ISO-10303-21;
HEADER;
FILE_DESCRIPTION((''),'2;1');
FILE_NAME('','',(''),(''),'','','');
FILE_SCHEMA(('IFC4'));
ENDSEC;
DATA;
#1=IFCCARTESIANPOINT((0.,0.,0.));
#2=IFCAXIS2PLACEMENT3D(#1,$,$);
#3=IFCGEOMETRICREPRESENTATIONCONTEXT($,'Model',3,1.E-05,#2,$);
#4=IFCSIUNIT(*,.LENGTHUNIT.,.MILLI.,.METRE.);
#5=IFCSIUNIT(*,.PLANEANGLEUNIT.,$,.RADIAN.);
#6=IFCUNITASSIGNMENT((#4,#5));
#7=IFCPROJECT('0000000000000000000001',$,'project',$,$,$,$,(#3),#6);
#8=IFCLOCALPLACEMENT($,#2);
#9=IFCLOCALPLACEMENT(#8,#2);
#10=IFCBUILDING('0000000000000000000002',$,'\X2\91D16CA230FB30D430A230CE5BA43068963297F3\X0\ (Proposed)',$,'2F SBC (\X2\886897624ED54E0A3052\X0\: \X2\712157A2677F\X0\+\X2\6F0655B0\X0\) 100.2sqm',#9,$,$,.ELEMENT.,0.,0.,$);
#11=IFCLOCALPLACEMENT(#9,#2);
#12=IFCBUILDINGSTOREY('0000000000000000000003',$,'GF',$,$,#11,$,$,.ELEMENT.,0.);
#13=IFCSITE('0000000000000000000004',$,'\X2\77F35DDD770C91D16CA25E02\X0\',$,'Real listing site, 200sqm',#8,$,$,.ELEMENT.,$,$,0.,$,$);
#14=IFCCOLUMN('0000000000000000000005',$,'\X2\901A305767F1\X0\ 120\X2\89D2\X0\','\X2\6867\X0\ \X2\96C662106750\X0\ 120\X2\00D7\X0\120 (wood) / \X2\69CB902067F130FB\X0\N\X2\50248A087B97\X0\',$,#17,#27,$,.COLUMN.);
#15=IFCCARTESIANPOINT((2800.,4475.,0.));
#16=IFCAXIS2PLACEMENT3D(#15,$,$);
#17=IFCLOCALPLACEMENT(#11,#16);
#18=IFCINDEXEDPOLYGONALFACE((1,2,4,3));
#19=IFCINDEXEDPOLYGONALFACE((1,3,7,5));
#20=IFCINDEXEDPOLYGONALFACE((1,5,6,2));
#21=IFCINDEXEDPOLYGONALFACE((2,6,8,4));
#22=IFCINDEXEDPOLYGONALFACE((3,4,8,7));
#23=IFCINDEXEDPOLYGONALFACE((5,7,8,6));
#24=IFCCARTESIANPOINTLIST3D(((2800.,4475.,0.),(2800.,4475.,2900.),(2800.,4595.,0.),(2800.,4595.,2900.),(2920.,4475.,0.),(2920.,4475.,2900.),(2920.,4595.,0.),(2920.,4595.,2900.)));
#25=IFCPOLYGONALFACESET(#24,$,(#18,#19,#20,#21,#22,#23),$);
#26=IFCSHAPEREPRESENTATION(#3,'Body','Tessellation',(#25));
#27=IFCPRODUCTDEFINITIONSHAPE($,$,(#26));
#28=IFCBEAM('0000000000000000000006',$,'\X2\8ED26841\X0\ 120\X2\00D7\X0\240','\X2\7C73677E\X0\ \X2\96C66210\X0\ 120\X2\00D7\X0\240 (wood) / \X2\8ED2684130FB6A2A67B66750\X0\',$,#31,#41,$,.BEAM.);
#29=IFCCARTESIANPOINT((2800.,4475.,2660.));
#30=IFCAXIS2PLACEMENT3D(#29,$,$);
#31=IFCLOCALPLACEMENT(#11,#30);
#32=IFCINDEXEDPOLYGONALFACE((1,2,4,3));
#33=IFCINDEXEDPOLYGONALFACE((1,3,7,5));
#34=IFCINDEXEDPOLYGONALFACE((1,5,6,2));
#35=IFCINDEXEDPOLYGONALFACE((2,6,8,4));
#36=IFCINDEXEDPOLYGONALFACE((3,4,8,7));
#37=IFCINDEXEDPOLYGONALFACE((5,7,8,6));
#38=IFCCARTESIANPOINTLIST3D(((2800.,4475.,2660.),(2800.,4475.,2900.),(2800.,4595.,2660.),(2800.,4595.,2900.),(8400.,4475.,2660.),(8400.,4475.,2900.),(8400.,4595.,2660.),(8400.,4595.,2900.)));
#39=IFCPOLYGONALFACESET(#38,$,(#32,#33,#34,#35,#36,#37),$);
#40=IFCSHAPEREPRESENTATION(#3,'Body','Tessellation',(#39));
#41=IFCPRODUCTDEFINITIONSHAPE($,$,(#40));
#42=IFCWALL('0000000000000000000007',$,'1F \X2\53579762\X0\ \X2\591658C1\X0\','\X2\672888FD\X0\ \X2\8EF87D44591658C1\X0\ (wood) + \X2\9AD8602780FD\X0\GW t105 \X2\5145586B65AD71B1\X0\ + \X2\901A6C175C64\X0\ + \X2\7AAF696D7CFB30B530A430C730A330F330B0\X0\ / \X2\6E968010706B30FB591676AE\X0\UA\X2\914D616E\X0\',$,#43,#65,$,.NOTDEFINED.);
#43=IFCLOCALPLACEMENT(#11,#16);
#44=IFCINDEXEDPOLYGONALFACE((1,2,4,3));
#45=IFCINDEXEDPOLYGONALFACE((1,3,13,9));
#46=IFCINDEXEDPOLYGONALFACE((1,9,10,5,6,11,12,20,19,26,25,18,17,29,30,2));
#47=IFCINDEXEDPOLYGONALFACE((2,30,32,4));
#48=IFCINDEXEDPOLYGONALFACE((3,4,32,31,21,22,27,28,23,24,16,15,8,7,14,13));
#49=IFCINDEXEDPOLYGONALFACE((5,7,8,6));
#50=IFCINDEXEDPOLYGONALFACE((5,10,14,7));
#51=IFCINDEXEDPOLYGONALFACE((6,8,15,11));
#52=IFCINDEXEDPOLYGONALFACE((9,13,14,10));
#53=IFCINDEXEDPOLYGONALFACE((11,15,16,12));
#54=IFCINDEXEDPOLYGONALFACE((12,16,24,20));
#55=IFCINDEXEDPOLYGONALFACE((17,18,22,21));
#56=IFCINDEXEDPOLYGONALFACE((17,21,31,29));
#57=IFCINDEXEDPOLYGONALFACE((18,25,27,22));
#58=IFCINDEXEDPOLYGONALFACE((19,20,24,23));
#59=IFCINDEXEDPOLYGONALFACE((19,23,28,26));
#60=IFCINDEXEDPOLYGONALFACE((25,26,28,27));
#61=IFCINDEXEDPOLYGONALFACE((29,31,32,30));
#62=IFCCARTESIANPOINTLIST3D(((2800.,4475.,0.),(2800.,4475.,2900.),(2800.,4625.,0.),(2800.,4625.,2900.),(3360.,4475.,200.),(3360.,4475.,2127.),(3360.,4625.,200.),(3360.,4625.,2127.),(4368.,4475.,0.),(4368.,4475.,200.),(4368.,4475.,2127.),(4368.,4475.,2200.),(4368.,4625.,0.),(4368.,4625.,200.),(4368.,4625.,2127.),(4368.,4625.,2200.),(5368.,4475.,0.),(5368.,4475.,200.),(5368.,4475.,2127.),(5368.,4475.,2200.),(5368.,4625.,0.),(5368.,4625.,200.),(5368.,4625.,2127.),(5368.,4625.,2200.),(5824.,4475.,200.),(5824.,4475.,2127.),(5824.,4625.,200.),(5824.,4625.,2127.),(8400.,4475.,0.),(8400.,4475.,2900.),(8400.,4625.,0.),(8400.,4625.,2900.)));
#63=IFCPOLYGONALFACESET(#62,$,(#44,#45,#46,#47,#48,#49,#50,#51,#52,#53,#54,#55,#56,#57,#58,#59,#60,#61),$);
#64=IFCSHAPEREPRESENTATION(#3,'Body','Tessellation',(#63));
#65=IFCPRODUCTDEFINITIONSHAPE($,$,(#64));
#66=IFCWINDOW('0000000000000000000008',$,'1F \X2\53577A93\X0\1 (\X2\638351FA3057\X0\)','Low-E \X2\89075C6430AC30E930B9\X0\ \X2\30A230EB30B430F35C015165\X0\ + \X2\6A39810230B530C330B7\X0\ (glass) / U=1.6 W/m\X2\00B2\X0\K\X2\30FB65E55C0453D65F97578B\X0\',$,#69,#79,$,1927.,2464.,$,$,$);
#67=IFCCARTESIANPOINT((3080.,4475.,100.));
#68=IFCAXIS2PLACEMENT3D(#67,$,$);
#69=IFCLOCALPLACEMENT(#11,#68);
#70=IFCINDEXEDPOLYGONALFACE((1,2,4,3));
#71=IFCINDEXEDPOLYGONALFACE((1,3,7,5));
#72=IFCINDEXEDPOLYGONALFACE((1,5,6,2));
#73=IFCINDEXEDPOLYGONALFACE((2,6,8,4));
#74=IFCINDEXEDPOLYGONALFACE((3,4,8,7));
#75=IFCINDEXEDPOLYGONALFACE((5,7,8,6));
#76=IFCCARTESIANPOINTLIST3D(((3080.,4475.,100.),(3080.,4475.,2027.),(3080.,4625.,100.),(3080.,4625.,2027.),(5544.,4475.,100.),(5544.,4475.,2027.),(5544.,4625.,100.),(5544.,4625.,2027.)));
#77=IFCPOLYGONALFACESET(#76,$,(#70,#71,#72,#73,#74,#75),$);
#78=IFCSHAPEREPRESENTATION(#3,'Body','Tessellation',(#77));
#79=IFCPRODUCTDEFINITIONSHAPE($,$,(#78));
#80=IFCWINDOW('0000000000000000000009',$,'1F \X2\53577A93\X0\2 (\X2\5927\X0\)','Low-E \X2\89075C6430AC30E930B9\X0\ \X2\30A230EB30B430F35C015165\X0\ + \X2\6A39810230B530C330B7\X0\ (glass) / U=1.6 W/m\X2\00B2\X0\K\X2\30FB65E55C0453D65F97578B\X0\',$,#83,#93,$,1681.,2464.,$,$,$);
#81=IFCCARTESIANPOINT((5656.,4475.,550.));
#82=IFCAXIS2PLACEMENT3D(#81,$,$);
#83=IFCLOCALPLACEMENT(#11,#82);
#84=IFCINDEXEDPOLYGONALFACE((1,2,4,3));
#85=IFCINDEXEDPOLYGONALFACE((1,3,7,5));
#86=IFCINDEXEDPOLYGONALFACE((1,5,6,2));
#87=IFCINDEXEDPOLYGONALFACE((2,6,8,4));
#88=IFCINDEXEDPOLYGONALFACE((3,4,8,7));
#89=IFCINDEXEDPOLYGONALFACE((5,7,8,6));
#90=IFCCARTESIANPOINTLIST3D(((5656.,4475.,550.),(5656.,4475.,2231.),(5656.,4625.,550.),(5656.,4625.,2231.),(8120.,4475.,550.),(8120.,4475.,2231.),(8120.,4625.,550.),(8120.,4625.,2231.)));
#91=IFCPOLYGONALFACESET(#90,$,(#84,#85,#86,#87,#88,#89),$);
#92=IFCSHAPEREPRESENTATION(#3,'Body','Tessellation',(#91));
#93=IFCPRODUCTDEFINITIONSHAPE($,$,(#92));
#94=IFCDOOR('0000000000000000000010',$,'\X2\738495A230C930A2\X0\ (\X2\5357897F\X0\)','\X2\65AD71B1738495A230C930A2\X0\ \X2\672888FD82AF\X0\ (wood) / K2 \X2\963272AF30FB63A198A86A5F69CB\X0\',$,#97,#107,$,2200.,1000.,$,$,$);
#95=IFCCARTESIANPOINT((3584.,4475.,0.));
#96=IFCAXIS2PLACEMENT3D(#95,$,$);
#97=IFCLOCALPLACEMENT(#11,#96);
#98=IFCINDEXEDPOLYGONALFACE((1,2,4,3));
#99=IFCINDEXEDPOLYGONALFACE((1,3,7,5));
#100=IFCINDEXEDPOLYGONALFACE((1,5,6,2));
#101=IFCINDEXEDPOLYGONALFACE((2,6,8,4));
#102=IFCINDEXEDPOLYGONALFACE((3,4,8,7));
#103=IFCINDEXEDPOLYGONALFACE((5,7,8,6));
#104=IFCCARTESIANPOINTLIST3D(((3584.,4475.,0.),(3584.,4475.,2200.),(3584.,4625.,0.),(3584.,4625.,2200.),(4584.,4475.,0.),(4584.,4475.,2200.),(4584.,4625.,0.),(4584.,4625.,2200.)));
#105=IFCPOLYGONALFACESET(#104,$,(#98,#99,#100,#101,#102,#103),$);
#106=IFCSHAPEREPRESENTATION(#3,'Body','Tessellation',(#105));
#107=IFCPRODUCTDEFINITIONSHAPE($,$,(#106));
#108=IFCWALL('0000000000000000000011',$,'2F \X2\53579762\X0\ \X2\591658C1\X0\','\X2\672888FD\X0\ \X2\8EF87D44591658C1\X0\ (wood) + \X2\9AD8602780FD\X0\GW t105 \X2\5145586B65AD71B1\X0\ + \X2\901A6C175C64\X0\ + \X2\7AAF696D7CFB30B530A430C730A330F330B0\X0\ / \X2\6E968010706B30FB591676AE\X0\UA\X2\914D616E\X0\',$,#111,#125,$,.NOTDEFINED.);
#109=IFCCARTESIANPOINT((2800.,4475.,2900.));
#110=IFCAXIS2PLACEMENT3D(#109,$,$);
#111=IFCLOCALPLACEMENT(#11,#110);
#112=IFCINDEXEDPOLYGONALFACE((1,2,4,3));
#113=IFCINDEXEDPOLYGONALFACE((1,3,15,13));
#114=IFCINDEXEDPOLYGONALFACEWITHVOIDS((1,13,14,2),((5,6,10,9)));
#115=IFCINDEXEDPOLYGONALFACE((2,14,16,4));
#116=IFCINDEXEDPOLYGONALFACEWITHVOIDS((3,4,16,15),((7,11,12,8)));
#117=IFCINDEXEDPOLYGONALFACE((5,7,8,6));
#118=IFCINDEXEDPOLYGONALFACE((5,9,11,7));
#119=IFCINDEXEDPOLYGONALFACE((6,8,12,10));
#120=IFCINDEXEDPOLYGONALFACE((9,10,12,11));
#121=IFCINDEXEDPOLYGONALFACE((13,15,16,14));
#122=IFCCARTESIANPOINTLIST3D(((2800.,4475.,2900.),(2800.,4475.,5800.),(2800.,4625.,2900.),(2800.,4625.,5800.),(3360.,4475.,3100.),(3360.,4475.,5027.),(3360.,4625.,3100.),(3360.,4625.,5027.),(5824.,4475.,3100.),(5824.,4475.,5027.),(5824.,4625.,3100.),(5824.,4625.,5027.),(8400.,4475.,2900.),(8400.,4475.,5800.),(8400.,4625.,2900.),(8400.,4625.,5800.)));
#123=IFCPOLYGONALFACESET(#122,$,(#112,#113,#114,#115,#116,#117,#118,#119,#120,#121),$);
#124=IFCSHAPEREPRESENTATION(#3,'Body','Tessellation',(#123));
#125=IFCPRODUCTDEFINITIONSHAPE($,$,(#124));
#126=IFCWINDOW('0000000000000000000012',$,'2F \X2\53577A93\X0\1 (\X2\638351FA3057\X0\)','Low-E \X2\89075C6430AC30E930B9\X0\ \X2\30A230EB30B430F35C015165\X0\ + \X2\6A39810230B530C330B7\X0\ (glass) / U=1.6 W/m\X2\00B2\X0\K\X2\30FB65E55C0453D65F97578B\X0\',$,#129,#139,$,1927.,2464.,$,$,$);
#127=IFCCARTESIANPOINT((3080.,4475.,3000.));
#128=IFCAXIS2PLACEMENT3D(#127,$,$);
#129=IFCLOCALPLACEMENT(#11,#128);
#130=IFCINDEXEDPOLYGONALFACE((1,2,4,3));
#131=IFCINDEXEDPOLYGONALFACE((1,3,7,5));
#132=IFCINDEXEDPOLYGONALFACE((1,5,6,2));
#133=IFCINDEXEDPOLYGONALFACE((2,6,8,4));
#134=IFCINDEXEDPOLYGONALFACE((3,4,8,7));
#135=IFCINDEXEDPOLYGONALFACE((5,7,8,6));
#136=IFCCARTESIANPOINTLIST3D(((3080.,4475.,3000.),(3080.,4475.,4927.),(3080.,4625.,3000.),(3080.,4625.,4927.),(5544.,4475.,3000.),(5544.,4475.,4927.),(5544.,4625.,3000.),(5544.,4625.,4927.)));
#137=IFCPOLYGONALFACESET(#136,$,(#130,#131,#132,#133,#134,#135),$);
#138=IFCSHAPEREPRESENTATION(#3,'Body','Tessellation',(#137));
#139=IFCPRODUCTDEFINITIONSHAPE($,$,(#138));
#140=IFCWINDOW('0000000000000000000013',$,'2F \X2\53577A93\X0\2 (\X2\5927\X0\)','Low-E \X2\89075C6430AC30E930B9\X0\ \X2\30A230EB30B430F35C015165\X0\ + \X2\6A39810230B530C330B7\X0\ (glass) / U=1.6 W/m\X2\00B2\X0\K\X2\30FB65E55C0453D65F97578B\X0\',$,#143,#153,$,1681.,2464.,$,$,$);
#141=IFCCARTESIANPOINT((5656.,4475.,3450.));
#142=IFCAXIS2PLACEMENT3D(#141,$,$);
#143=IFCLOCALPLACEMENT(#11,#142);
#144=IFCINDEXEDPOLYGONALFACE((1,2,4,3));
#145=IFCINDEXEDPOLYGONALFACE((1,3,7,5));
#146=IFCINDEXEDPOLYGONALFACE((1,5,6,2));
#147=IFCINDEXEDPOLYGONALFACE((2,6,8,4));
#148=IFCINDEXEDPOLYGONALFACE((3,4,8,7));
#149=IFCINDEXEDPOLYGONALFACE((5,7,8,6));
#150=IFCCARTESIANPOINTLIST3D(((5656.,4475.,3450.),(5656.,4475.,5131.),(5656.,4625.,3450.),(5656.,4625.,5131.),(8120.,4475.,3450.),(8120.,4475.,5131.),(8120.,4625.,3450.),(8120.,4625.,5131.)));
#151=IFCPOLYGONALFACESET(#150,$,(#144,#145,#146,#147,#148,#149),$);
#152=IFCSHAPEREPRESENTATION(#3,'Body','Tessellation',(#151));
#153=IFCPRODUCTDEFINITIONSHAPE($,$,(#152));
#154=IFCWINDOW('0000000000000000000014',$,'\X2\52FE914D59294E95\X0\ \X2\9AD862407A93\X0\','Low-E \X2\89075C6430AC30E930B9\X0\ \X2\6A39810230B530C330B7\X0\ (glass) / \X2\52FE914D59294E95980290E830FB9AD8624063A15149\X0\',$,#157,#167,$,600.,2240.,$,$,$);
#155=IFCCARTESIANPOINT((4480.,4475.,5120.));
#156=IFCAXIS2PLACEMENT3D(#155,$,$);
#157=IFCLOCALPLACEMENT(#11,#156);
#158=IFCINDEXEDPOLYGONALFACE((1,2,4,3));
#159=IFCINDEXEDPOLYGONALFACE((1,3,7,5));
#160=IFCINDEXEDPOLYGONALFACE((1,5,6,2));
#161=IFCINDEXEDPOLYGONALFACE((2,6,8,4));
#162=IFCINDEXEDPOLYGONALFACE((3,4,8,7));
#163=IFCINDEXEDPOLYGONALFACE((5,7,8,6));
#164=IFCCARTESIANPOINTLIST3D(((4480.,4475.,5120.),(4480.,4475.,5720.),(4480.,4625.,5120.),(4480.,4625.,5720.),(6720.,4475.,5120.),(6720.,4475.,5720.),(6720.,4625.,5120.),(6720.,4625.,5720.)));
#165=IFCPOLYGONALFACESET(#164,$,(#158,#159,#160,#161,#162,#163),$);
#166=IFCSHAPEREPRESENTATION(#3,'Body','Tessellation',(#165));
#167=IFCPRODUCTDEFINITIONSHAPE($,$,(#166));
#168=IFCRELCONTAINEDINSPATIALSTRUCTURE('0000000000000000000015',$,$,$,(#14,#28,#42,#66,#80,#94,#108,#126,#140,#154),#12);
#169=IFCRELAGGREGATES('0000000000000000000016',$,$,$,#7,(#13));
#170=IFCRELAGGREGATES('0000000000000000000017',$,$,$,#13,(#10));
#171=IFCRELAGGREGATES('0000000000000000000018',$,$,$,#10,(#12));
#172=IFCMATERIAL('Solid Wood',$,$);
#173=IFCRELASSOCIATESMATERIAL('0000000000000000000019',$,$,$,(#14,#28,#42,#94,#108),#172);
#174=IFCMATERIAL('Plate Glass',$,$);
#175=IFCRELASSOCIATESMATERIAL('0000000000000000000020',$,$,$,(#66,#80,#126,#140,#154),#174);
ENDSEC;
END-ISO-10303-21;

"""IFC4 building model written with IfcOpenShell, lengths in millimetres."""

from ifc_helpers import new_model, si_unit, frame, frame_2d, origin, place, context, project, spatial, rectangle, extrude, material, element, fill, save


model = new_model("IFC4")

# Units and contexts
model_context = context("Model", 3, precision=1e-05, world=origin())
ifc_project = project(units=[si_unit("LENGTHUNIT", "METRE", prefix="MILLI"), si_unit("PLANEANGLEUNIT", "RADIAN")], contexts=[model_context])

# Site, building, storey
site_placement = place(None, origin())
site = spatial("IfcSite", under=ifc_project, at=site_placement, Name="石川県金沢市", ObjectType="Real listing site, 200sqm", CompositionType="ELEMENT", RefElevation=0.0)
building_placement = place(site_placement, origin())
building = spatial("IfcBuilding", under=site, at=building_placement, Name="金沢・ピアノ室と防音 (Proposed)", ObjectType="2F SBC (表面仕上げ: 無垢板+漆喰) 100.2sqm", CompositionType="ELEMENT", ElevationOfRefHeight=0.0, ElevationOfTerrain=0.0)
storey_placement = place(building_placement, origin())
storey = spatial("IfcBuildingStorey", under=building, at=storey_placement, Name="GF", CompositionType="ELEMENT", Elevation=0.0)

# Column
ifc_material_1 = material(Name="Solid Wood")
column_placement = place(storey_placement, frame((2800.0, 4475.0, 0.0)))
element("IfcColumn", 1, at=column_placement, inside=storey, material=ifc_material_1, Name="通し柱 120角", Description="桧 集成材 120×120 (wood) / 構造柱・N値計算", PredefinedType="COLUMN", context=model_context, shape_type="SweptSolid", body=[
    extrude(rectangle(XDim=120.0, YDim=120.0, at=frame_2d((60.0, 60.0))), frame((2800.0, 4475.0, 0.0)), (0.0, 0.0, 1.0), 2900.0),
])

# Beam
beam_1_placement = place(storey_placement, frame((2800.0, 4475.0, 2660.0)))
element("IfcBeam", 2, at=beam_1_placement, inside=storey, material=ifc_material_1, Name="軒桁 120×240", Description="米松 集成 120×240 (wood) / 軒桁・横架材", PredefinedType="BEAM", context=model_context, shape_type="SweptSolid", body=[
    extrude(rectangle(XDim=5600.0, YDim=120.0, at=frame_2d((2800.0, 60.0))), frame((2800.0, 4475.0, 2660.0)), (0.0, 0.0, 1.0), 240.0),
])

# Wall, openings, windows, door
wall_1_placement = place(storey_placement, frame((2800.0, 4475.0, 0.0)))
wall_1 = element("IfcWall", 3, at=wall_1_placement, inside=storey, material=ifc_material_1, Name="1F 南面 外壁", Description="木製 軸組外壁 (wood) + 高性能GW t105 充填断熱 + 通気層 + 窯業系サイディング / 準耐火・外皮UA配慮", PredefinedType="NOTDEFINED", context=model_context, shape_type="SweptSolid", body=[
    extrude(rectangle(XDim=5600.0, YDim=150.0, at=frame_2d((2800.0, 75.0))), frame((2800.0, 4475.0, 0.0)), (0.0, 0.0, 1.0), 2900.0),
])
opening_1_placement = place(storey_placement, frame((3080.0, 4475.0, 100.0)))
opening_1 = element("IfcOpeningElement", 4, at=opening_1_placement, cuts=wall_1, PredefinedType="NOTDEFINED", context=model_context, shape_type="SweptSolid", body=[
    extrude(rectangle(XDim=2464.0, YDim=150.0, at=frame_2d((1232.0, 75.0))), frame((3080.0, 4475.0, 100.0)), (0.0, 0.0, 1.0), 1927.0),
])
opening_2_placement = place(storey_placement, frame((5656.0, 4475.0, 550.0)))
opening_2 = element("IfcOpeningElement", 5, at=opening_2_placement, cuts=wall_1, PredefinedType="NOTDEFINED", context=model_context, shape_type="SweptSolid", body=[
    extrude(rectangle(XDim=2464.0, YDim=150.0, at=frame_2d((1232.0, 75.0))), frame((5656.0, 4475.0, 550.0)), (0.0, 0.0, 1.0), 1681.0),
])
opening_3_placement = place(storey_placement, frame((3584.0, 4475.0, 0.0)))
opening_3 = element("IfcOpeningElement", 6, at=opening_3_placement, cuts=wall_1, PredefinedType="NOTDEFINED", context=model_context, shape_type="SweptSolid", body=[
    extrude(rectangle(XDim=1000.0, YDim=150.0, at=frame_2d((500.0, 75.0))), frame((3584.0, 4475.0, 0.0)), (0.0, 0.0, 1.0), 2200.0),
])
ifc_material_2 = material(Name="Plate Glass")
window_1_placement = place(storey_placement, frame((3080.0, 4475.0, 100.0)))
window_1 = element("IfcWindow", 7, at=window_1_placement, inside=storey, material=ifc_material_2, Name="1F 南窓1 (掃出し)", Description="Low-E 複層ガラス アルゴン封入 + 樹脂サッシ (glass) / U=1.6 W/m²K・日射取得型", OverallHeight=1927.0, OverallWidth=2464.0, context=model_context, shape_type="SweptSolid", body=[
    extrude(rectangle(XDim=2464.0, YDim=150.0, at=frame_2d((1232.0, 75.0))), frame((3080.0, 4475.0, 100.0)), (0.0, 0.0, 1.0), 1927.0),
])
fill(opening_1, window_1)
window_2_placement = place(storey_placement, frame((5656.0, 4475.0, 550.0)))
window_2 = element("IfcWindow", 8, at=window_2_placement, inside=storey, material=ifc_material_2, Name="1F 南窓2 (大)", Description="Low-E 複層ガラス アルゴン封入 + 樹脂サッシ (glass) / U=1.6 W/m²K・日射取得型", OverallHeight=1681.0, OverallWidth=2464.0, context=model_context, shape_type="SweptSolid", body=[
    extrude(rectangle(XDim=2464.0, YDim=150.0, at=frame_2d((1232.0, 75.0))), frame((5656.0, 4475.0, 550.0)), (0.0, 0.0, 1.0), 1681.0),
])
fill(opening_2, window_2)
door_placement = place(storey_placement, frame((3584.0, 4475.0, 0.0)))
door = element("IfcDoor", 9, at=door_placement, inside=storey, material=ifc_material_1, Name="玄関ドア (南西)", Description="断熱玄関ドア 木製芯 (wood) / K2 防犯・採風機構", OverallHeight=2200.0, OverallWidth=1000.0, context=model_context, shape_type="SweptSolid", body=[
    extrude(rectangle(XDim=1000.0, YDim=150.0, at=frame_2d((500.0, 75.0))), frame((3584.0, 4475.0, 0.0)), (0.0, 0.0, 1.0), 2200.0),
])
fill(opening_3, door)

# Wall, openings, windows
wall_2_placement = place(storey_placement, frame((2800.0, 4475.0, 2900.0)))
wall_2 = element("IfcWall", 10, at=wall_2_placement, inside=storey, material=ifc_material_1, Name="2F 南面 外壁", Description="木製 軸組外壁 (wood) + 高性能GW t105 充填断熱 + 通気層 + 窯業系サイディング / 準耐火・外皮UA配慮", PredefinedType="NOTDEFINED", context=model_context, shape_type="SweptSolid", body=[
    extrude(rectangle(XDim=5600.0, YDim=150.0, at=frame_2d((2800.0, 75.0))), frame((2800.0, 4475.0, 2900.0)), (0.0, 0.0, 1.0), 2900.0),
])
opening_4_placement = place(storey_placement, frame((3080.0, 4475.0, 3000.0)))
opening_4 = element("IfcOpeningElement", 11, at=opening_4_placement, cuts=wall_2, PredefinedType="NOTDEFINED", context=model_context, shape_type="SweptSolid", body=[
    extrude(rectangle(XDim=2464.0, YDim=150.0, at=frame_2d((1232.0, 75.0))), frame((3080.0, 4475.0, 3000.0)), (0.0, 0.0, 1.0), 1927.0),
])
opening_5_placement = place(storey_placement, frame((5656.0, 4475.0, 3450.0)))
opening_5 = element("IfcOpeningElement", 12, at=opening_5_placement, cuts=wall_2, PredefinedType="NOTDEFINED", context=model_context, shape_type="SweptSolid", body=[
    extrude(rectangle(XDim=2464.0, YDim=150.0, at=frame_2d((1232.0, 75.0))), frame((5656.0, 4475.0, 3450.0)), (0.0, 0.0, 1.0), 1681.0),
])
opening_6_placement = place(storey_placement, frame((4480.0, 4475.0, 5120.0)))
opening_6 = element("IfcOpeningElement", 13, at=opening_6_placement, cuts=wall_2, PredefinedType="NOTDEFINED", context=model_context, shape_type="SweptSolid", body=[
    extrude(rectangle(XDim=2240.0, YDim=150.0, at=frame_2d((1120.0, 75.0))), frame((4480.0, 4475.0, 5120.0)), (0.0, 0.0, 1.0), 600.0),
])
window_3_placement = place(storey_placement, frame((3080.0, 4475.0, 3000.0)))
window_3 = element("IfcWindow", 14, at=window_3_placement, inside=storey, material=ifc_material_2, Name="2F 南窓1 (掃出し)", Description="Low-E 複層ガラス アルゴン封入 + 樹脂サッシ (glass) / U=1.6 W/m²K・日射取得型", OverallHeight=1927.0, OverallWidth=2464.0, context=model_context, shape_type="SweptSolid", body=[
    extrude(rectangle(XDim=2464.0, YDim=150.0, at=frame_2d((1232.0, 75.0))), frame((3080.0, 4475.0, 3000.0)), (0.0, 0.0, 1.0), 1927.0),
])
fill(opening_4, window_3)
window_4_placement = place(storey_placement, frame((5656.0, 4475.0, 3450.0)))
window_4 = element("IfcWindow", 15, at=window_4_placement, inside=storey, material=ifc_material_2, Name="2F 南窓2 (大)", Description="Low-E 複層ガラス アルゴン封入 + 樹脂サッシ (glass) / U=1.6 W/m²K・日射取得型", OverallHeight=1681.0, OverallWidth=2464.0, context=model_context, shape_type="SweptSolid", body=[
    extrude(rectangle(XDim=2464.0, YDim=150.0, at=frame_2d((1232.0, 75.0))), frame((5656.0, 4475.0, 3450.0)), (0.0, 0.0, 1.0), 1681.0),
])
fill(opening_5, window_4)
window_5_placement = place(storey_placement, frame((4480.0, 4475.0, 5120.0)))
window_5 = element("IfcWindow", 16, at=window_5_placement, inside=storey, material=ifc_material_2, Name="勾配天井 高所窓", Description="Low-E 複層ガラス 樹脂サッシ (glass) / 勾配天井頂部・高所採光", OverallHeight=600.0, OverallWidth=2240.0, context=model_context, shape_type="SweptSolid", body=[
    extrude(rectangle(XDim=2240.0, YDim=150.0, at=frame_2d((1120.0, 75.0))), frame((4480.0, 4475.0, 5120.0)), (0.0, 0.0, 1.0), 600.0),
])
fill(opening_6, window_5)

save(model, "model.ifc")
